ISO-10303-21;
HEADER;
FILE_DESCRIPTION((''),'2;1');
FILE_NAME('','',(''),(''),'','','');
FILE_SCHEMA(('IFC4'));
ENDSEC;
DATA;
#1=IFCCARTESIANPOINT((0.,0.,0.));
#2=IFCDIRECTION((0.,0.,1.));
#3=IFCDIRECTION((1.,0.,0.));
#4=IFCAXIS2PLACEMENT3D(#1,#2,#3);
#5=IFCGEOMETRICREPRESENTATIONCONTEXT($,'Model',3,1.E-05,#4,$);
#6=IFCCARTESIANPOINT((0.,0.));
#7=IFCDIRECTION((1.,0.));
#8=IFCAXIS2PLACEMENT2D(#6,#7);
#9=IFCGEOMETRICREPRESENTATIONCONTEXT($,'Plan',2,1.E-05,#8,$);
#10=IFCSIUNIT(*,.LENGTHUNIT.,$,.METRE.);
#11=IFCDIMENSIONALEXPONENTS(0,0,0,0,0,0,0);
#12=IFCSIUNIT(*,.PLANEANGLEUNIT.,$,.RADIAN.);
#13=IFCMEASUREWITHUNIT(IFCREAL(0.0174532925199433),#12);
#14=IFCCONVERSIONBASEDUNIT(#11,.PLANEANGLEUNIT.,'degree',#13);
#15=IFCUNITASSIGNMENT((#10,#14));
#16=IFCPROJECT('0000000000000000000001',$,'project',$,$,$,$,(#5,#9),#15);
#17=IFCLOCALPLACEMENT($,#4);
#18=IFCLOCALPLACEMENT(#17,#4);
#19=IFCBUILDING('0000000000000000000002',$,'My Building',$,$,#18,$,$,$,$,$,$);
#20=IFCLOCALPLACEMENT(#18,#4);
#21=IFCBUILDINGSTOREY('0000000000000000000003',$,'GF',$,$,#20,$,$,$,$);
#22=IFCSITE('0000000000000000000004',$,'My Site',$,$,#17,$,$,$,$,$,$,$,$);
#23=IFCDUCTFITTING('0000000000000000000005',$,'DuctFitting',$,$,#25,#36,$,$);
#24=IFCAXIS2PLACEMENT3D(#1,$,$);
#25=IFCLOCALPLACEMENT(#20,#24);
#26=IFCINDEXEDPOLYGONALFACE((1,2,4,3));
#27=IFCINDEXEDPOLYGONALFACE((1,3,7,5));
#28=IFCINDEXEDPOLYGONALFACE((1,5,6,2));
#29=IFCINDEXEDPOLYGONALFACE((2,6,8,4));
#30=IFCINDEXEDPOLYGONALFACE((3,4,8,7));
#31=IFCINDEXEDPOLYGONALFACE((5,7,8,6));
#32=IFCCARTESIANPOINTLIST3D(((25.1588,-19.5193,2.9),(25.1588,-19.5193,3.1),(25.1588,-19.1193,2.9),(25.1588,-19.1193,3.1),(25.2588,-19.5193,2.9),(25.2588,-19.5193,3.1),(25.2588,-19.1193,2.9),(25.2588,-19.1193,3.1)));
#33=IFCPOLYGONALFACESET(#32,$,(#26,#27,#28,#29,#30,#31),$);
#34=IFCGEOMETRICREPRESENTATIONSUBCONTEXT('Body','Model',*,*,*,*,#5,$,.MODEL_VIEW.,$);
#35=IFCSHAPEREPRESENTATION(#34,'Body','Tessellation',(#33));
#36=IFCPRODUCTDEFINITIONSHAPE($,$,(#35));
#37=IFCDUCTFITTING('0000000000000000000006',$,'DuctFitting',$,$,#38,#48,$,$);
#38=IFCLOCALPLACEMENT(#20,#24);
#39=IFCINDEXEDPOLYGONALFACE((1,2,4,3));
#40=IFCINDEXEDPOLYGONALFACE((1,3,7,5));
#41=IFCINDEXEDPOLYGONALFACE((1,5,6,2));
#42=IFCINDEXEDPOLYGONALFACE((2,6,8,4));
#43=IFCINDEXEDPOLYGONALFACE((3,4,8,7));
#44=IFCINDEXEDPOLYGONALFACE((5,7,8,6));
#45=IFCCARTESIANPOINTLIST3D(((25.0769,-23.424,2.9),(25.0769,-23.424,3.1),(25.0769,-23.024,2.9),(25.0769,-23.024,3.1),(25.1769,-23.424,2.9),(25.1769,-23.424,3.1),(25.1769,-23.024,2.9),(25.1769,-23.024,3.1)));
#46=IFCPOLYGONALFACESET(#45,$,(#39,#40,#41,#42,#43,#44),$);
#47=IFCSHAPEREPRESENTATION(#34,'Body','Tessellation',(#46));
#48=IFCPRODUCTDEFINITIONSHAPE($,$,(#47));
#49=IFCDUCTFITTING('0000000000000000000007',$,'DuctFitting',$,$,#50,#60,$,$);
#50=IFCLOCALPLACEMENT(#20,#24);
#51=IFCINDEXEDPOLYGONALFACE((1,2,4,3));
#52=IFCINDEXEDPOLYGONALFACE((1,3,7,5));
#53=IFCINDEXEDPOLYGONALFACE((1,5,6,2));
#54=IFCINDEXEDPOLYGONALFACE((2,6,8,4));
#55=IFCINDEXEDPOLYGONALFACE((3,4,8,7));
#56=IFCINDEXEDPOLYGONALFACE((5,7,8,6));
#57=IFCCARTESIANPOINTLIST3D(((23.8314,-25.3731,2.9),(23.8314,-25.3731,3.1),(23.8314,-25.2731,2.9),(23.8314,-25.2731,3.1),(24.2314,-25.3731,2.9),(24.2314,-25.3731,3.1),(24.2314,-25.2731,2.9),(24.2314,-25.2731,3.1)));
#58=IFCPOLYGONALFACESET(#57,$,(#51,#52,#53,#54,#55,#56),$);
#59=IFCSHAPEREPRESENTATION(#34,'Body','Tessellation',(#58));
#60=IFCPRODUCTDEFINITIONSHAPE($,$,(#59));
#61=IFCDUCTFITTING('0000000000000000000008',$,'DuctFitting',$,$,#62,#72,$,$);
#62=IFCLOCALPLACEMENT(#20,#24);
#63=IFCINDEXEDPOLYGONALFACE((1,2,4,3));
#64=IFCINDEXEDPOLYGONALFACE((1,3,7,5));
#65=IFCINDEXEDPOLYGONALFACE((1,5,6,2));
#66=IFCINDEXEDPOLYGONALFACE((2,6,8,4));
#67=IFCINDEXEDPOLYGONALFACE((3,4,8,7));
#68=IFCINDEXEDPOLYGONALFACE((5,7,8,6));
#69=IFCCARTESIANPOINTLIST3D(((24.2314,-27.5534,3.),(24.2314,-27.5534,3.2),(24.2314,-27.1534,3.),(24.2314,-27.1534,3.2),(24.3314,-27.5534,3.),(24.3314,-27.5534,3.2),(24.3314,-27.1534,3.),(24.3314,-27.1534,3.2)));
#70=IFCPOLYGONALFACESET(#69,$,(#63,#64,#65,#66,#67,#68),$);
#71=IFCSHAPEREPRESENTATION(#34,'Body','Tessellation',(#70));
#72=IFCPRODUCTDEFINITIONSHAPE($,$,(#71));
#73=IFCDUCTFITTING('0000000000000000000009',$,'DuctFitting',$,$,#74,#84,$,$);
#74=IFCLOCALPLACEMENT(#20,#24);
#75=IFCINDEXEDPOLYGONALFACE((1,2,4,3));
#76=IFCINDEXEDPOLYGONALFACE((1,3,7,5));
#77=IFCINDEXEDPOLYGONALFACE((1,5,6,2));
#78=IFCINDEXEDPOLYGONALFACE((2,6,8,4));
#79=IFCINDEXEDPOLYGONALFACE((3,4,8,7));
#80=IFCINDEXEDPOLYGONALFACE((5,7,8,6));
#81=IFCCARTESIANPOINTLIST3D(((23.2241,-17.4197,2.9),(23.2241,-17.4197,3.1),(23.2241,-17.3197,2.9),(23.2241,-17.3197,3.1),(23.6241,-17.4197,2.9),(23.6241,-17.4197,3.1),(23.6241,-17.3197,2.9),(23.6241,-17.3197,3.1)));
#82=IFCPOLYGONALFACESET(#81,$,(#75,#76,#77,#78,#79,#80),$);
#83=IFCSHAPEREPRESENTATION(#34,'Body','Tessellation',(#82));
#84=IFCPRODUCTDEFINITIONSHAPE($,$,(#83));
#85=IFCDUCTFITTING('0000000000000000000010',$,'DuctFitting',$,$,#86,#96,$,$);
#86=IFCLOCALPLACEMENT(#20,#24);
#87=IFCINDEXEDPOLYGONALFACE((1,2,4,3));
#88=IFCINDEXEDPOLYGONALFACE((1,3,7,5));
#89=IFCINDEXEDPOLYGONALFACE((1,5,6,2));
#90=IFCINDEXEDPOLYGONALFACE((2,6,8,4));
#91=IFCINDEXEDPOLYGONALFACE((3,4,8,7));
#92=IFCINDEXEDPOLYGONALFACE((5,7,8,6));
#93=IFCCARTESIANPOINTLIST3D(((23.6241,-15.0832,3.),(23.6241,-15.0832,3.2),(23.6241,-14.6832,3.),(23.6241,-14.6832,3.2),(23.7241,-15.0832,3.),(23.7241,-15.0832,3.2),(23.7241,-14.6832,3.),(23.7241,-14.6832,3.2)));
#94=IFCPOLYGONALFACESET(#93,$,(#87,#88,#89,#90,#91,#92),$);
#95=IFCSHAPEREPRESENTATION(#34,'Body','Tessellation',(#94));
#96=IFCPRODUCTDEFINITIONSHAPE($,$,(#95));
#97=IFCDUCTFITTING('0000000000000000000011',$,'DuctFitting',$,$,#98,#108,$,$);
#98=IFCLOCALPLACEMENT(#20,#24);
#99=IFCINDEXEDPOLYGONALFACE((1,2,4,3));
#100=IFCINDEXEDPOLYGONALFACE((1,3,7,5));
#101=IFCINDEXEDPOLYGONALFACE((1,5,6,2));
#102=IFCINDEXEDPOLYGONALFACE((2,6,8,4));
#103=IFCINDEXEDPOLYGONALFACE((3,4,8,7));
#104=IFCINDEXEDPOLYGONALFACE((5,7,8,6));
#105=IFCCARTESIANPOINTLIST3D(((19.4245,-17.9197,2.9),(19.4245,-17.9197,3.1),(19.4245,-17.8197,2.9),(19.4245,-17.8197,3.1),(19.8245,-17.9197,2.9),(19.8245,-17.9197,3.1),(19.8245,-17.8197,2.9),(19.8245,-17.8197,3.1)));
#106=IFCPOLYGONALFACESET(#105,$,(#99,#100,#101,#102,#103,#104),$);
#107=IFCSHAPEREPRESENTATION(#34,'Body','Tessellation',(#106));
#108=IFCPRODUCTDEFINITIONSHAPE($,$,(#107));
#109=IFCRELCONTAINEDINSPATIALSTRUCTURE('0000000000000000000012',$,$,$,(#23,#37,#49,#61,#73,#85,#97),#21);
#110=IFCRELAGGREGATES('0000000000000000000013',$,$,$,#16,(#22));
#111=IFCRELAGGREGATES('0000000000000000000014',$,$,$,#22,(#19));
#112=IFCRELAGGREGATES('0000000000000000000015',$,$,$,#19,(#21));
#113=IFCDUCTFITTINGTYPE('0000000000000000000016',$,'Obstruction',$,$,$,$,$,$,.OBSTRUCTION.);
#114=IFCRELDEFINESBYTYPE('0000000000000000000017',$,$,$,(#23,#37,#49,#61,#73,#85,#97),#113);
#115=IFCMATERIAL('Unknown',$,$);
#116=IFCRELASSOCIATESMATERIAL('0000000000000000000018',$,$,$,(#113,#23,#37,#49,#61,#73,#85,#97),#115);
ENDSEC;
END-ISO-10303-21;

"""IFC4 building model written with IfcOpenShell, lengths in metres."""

from ifc_helpers import new_model, entity, si_unit, converted_unit, frame, origin_with_axes, origin_2d_with_axis, place, context, subcontext, project, spatial, rectangle, extrude, material, material_profile, profile_set, profile_usage, type_object, element, save


model = new_model("IFC4")

# Units and contexts
model_context = context("Model", 3, precision=1e-05, world=origin_with_axes())
plan_context = context("Plan", 2, precision=1e-05, world=origin_2d_with_axis())
body_context_1 = subcontext(model_context, "Body", "Model", "MODEL_VIEW")
ifc_project = project(units=[si_unit("LENGTHUNIT", "METRE"), converted_unit("PLANEANGLEUNIT", "degree", entity("IfcReal", 0.0174532925199433), si_unit("PLANEANGLEUNIT", "RADIAN"), dimensions=[0, 0, 0, 0, 0, 0, 0])], contexts=[model_context, plan_context])

# Site, building, storey
site_placement = place(None, origin_with_axes())
site = spatial("IfcSite", under=ifc_project, at=site_placement, Name="My Site")
building_placement = place(site_placement, origin_with_axes())
building = spatial("IfcBuilding", under=site, at=building_placement, Name="My Building")
storey_placement = place(building_placement, origin_with_axes())
storey = spatial("IfcBuildingStorey", under=building, at=storey_placement, Name="GF")

# Shared definitions
ifc_material = material(Name="Unknown")

# Duct fittings
ifc_material_profile_1 = material_profile(ifc_material, rectangle(XDim=0.4, YDim=0.2))
ifc_profile_set_1 = profile_set([ifc_material_profile_1])
ifc_profile_usage_1 = profile_usage(ifc_profile_set_1, cardinal=5)
duct_fitting_type = type_object("IfcDuctFittingType", Name="Obstruction", PredefinedType="OBSTRUCTION", material=ifc_profile_set_1)
duct_fitting_1_placement = place(storey_placement, frame((25.1588, -19.3193, 3.0), z_axis=(1.0, 0.0, 0.0), x_axis=(0.0, 1.0, 0.0)))
element("IfcDuctFitting", 1, at=duct_fitting_1_placement, inside=storey, type_object=duct_fitting_type, material=ifc_profile_usage_1, Name="DuctFitting", context=body_context_1, shape_type="SweptSolid", body=[
    extrude(rectangle(XDim=0.4, YDim=0.2), origin_with_axes(), (0.0, 0.0, 1.0), 0.1),
])
ifc_profile_usage_2 = profile_usage(ifc_profile_set_1, cardinal=5)
duct_fitting_2_placement = place(storey_placement, frame((25.0769, -23.224, 3.0), z_axis=(1.0, 0.0, 0.0), x_axis=(0.0, 1.0, 0.0)))
element("IfcDuctFitting", 2, at=duct_fitting_2_placement, inside=storey, type_object=duct_fitting_type, material=ifc_profile_usage_2, Name="DuctFitting", context=body_context_1, shape_type="SweptSolid", body=[
    extrude(rectangle(XDim=0.4, YDim=0.2), origin_with_axes(), (0.0, 0.0, 1.0), 0.1),
])
ifc_profile_usage_3 = profile_usage(ifc_profile_set_1, cardinal=5)
duct_fitting_3_placement = place(storey_placement, frame((24.0314, -25.3731, 3.0), z_axis=(0.0, 1.0, 0.0), x_axis=(-1.0, 0.0, 0.0)))
element("IfcDuctFitting", 3, at=duct_fitting_3_placement, inside=storey, type_object=duct_fitting_type, material=ifc_profile_usage_3, Name="DuctFitting", context=body_context_1, shape_type="SweptSolid", body=[
    extrude(rectangle(XDim=0.4, YDim=0.2), origin_with_axes(), (0.0, 0.0, 1.0), 0.1),
])
ifc_profile_usage_4 = profile_usage(ifc_profile_set_1, cardinal=5)
duct_fitting_4_placement = place(storey_placement, frame((24.2314, -27.3534, 3.1), z_axis=(1.0, 0.0, 0.0), x_axis=(0.0, 1.0, 0.0)))
element("IfcDuctFitting", 4, at=duct_fitting_4_placement, inside=storey, type_object=duct_fitting_type, material=ifc_profile_usage_4, Name="DuctFitting", context=body_context_1, shape_type="SweptSolid", body=[
    extrude(rectangle(XDim=0.4, YDim=0.2), origin_with_axes(), (0.0, 0.0, 1.0), 0.1),
])
ifc_profile_usage_5 = profile_usage(ifc_profile_set_1, cardinal=5)
duct_fitting_5_placement = place(storey_placement, frame((23.4241, -17.4197, 3.0), z_axis=(0.0, 1.0, 0.0), x_axis=(-1.0, 0.0, 0.0)))
element("IfcDuctFitting", 5, at=duct_fitting_5_placement, inside=storey, type_object=duct_fitting_type, material=ifc_profile_usage_5, Name="DuctFitting", context=body_context_1, shape_type="SweptSolid", body=[
    extrude(rectangle(XDim=0.4, YDim=0.2), origin_with_axes(), (0.0, 0.0, 1.0), 0.1),
])
ifc_profile_usage_6 = profile_usage(ifc_profile_set_1, cardinal=5)
duct_fitting_6_placement = place(storey_placement, frame((23.6241, -14.8832, 3.1), z_axis=(1.0, 0.0, 0.0), x_axis=(0.0, 1.0, 0.0)))
element("IfcDuctFitting", 6, at=duct_fitting_6_placement, inside=storey, type_object=duct_fitting_type, material=ifc_profile_usage_6, Name="DuctFitting", context=body_context_1, shape_type="SweptSolid", body=[
    extrude(rectangle(XDim=0.4, YDim=0.2), origin_with_axes(), (0.0, 0.0, 1.0), 0.1),
])
ifc_profile_usage_7 = profile_usage(ifc_profile_set_1, cardinal=5)
duct_fitting_7_placement = place(storey_placement, frame((19.6245, -17.9197, 3.0), z_axis=(0.0, 1.0, 0.0), x_axis=(-1.0, 0.0, 0.0)))
element("IfcDuctFitting", 7, at=duct_fitting_7_placement, inside=storey, type_object=duct_fitting_type, material=ifc_profile_usage_7, Name="DuctFitting", context=body_context_1, shape_type="SweptSolid", body=[
    extrude(rectangle(XDim=0.4, YDim=0.2), origin_with_axes(), (0.0, 0.0, 1.0), 0.1),
])

save(model, "model.ifc")
